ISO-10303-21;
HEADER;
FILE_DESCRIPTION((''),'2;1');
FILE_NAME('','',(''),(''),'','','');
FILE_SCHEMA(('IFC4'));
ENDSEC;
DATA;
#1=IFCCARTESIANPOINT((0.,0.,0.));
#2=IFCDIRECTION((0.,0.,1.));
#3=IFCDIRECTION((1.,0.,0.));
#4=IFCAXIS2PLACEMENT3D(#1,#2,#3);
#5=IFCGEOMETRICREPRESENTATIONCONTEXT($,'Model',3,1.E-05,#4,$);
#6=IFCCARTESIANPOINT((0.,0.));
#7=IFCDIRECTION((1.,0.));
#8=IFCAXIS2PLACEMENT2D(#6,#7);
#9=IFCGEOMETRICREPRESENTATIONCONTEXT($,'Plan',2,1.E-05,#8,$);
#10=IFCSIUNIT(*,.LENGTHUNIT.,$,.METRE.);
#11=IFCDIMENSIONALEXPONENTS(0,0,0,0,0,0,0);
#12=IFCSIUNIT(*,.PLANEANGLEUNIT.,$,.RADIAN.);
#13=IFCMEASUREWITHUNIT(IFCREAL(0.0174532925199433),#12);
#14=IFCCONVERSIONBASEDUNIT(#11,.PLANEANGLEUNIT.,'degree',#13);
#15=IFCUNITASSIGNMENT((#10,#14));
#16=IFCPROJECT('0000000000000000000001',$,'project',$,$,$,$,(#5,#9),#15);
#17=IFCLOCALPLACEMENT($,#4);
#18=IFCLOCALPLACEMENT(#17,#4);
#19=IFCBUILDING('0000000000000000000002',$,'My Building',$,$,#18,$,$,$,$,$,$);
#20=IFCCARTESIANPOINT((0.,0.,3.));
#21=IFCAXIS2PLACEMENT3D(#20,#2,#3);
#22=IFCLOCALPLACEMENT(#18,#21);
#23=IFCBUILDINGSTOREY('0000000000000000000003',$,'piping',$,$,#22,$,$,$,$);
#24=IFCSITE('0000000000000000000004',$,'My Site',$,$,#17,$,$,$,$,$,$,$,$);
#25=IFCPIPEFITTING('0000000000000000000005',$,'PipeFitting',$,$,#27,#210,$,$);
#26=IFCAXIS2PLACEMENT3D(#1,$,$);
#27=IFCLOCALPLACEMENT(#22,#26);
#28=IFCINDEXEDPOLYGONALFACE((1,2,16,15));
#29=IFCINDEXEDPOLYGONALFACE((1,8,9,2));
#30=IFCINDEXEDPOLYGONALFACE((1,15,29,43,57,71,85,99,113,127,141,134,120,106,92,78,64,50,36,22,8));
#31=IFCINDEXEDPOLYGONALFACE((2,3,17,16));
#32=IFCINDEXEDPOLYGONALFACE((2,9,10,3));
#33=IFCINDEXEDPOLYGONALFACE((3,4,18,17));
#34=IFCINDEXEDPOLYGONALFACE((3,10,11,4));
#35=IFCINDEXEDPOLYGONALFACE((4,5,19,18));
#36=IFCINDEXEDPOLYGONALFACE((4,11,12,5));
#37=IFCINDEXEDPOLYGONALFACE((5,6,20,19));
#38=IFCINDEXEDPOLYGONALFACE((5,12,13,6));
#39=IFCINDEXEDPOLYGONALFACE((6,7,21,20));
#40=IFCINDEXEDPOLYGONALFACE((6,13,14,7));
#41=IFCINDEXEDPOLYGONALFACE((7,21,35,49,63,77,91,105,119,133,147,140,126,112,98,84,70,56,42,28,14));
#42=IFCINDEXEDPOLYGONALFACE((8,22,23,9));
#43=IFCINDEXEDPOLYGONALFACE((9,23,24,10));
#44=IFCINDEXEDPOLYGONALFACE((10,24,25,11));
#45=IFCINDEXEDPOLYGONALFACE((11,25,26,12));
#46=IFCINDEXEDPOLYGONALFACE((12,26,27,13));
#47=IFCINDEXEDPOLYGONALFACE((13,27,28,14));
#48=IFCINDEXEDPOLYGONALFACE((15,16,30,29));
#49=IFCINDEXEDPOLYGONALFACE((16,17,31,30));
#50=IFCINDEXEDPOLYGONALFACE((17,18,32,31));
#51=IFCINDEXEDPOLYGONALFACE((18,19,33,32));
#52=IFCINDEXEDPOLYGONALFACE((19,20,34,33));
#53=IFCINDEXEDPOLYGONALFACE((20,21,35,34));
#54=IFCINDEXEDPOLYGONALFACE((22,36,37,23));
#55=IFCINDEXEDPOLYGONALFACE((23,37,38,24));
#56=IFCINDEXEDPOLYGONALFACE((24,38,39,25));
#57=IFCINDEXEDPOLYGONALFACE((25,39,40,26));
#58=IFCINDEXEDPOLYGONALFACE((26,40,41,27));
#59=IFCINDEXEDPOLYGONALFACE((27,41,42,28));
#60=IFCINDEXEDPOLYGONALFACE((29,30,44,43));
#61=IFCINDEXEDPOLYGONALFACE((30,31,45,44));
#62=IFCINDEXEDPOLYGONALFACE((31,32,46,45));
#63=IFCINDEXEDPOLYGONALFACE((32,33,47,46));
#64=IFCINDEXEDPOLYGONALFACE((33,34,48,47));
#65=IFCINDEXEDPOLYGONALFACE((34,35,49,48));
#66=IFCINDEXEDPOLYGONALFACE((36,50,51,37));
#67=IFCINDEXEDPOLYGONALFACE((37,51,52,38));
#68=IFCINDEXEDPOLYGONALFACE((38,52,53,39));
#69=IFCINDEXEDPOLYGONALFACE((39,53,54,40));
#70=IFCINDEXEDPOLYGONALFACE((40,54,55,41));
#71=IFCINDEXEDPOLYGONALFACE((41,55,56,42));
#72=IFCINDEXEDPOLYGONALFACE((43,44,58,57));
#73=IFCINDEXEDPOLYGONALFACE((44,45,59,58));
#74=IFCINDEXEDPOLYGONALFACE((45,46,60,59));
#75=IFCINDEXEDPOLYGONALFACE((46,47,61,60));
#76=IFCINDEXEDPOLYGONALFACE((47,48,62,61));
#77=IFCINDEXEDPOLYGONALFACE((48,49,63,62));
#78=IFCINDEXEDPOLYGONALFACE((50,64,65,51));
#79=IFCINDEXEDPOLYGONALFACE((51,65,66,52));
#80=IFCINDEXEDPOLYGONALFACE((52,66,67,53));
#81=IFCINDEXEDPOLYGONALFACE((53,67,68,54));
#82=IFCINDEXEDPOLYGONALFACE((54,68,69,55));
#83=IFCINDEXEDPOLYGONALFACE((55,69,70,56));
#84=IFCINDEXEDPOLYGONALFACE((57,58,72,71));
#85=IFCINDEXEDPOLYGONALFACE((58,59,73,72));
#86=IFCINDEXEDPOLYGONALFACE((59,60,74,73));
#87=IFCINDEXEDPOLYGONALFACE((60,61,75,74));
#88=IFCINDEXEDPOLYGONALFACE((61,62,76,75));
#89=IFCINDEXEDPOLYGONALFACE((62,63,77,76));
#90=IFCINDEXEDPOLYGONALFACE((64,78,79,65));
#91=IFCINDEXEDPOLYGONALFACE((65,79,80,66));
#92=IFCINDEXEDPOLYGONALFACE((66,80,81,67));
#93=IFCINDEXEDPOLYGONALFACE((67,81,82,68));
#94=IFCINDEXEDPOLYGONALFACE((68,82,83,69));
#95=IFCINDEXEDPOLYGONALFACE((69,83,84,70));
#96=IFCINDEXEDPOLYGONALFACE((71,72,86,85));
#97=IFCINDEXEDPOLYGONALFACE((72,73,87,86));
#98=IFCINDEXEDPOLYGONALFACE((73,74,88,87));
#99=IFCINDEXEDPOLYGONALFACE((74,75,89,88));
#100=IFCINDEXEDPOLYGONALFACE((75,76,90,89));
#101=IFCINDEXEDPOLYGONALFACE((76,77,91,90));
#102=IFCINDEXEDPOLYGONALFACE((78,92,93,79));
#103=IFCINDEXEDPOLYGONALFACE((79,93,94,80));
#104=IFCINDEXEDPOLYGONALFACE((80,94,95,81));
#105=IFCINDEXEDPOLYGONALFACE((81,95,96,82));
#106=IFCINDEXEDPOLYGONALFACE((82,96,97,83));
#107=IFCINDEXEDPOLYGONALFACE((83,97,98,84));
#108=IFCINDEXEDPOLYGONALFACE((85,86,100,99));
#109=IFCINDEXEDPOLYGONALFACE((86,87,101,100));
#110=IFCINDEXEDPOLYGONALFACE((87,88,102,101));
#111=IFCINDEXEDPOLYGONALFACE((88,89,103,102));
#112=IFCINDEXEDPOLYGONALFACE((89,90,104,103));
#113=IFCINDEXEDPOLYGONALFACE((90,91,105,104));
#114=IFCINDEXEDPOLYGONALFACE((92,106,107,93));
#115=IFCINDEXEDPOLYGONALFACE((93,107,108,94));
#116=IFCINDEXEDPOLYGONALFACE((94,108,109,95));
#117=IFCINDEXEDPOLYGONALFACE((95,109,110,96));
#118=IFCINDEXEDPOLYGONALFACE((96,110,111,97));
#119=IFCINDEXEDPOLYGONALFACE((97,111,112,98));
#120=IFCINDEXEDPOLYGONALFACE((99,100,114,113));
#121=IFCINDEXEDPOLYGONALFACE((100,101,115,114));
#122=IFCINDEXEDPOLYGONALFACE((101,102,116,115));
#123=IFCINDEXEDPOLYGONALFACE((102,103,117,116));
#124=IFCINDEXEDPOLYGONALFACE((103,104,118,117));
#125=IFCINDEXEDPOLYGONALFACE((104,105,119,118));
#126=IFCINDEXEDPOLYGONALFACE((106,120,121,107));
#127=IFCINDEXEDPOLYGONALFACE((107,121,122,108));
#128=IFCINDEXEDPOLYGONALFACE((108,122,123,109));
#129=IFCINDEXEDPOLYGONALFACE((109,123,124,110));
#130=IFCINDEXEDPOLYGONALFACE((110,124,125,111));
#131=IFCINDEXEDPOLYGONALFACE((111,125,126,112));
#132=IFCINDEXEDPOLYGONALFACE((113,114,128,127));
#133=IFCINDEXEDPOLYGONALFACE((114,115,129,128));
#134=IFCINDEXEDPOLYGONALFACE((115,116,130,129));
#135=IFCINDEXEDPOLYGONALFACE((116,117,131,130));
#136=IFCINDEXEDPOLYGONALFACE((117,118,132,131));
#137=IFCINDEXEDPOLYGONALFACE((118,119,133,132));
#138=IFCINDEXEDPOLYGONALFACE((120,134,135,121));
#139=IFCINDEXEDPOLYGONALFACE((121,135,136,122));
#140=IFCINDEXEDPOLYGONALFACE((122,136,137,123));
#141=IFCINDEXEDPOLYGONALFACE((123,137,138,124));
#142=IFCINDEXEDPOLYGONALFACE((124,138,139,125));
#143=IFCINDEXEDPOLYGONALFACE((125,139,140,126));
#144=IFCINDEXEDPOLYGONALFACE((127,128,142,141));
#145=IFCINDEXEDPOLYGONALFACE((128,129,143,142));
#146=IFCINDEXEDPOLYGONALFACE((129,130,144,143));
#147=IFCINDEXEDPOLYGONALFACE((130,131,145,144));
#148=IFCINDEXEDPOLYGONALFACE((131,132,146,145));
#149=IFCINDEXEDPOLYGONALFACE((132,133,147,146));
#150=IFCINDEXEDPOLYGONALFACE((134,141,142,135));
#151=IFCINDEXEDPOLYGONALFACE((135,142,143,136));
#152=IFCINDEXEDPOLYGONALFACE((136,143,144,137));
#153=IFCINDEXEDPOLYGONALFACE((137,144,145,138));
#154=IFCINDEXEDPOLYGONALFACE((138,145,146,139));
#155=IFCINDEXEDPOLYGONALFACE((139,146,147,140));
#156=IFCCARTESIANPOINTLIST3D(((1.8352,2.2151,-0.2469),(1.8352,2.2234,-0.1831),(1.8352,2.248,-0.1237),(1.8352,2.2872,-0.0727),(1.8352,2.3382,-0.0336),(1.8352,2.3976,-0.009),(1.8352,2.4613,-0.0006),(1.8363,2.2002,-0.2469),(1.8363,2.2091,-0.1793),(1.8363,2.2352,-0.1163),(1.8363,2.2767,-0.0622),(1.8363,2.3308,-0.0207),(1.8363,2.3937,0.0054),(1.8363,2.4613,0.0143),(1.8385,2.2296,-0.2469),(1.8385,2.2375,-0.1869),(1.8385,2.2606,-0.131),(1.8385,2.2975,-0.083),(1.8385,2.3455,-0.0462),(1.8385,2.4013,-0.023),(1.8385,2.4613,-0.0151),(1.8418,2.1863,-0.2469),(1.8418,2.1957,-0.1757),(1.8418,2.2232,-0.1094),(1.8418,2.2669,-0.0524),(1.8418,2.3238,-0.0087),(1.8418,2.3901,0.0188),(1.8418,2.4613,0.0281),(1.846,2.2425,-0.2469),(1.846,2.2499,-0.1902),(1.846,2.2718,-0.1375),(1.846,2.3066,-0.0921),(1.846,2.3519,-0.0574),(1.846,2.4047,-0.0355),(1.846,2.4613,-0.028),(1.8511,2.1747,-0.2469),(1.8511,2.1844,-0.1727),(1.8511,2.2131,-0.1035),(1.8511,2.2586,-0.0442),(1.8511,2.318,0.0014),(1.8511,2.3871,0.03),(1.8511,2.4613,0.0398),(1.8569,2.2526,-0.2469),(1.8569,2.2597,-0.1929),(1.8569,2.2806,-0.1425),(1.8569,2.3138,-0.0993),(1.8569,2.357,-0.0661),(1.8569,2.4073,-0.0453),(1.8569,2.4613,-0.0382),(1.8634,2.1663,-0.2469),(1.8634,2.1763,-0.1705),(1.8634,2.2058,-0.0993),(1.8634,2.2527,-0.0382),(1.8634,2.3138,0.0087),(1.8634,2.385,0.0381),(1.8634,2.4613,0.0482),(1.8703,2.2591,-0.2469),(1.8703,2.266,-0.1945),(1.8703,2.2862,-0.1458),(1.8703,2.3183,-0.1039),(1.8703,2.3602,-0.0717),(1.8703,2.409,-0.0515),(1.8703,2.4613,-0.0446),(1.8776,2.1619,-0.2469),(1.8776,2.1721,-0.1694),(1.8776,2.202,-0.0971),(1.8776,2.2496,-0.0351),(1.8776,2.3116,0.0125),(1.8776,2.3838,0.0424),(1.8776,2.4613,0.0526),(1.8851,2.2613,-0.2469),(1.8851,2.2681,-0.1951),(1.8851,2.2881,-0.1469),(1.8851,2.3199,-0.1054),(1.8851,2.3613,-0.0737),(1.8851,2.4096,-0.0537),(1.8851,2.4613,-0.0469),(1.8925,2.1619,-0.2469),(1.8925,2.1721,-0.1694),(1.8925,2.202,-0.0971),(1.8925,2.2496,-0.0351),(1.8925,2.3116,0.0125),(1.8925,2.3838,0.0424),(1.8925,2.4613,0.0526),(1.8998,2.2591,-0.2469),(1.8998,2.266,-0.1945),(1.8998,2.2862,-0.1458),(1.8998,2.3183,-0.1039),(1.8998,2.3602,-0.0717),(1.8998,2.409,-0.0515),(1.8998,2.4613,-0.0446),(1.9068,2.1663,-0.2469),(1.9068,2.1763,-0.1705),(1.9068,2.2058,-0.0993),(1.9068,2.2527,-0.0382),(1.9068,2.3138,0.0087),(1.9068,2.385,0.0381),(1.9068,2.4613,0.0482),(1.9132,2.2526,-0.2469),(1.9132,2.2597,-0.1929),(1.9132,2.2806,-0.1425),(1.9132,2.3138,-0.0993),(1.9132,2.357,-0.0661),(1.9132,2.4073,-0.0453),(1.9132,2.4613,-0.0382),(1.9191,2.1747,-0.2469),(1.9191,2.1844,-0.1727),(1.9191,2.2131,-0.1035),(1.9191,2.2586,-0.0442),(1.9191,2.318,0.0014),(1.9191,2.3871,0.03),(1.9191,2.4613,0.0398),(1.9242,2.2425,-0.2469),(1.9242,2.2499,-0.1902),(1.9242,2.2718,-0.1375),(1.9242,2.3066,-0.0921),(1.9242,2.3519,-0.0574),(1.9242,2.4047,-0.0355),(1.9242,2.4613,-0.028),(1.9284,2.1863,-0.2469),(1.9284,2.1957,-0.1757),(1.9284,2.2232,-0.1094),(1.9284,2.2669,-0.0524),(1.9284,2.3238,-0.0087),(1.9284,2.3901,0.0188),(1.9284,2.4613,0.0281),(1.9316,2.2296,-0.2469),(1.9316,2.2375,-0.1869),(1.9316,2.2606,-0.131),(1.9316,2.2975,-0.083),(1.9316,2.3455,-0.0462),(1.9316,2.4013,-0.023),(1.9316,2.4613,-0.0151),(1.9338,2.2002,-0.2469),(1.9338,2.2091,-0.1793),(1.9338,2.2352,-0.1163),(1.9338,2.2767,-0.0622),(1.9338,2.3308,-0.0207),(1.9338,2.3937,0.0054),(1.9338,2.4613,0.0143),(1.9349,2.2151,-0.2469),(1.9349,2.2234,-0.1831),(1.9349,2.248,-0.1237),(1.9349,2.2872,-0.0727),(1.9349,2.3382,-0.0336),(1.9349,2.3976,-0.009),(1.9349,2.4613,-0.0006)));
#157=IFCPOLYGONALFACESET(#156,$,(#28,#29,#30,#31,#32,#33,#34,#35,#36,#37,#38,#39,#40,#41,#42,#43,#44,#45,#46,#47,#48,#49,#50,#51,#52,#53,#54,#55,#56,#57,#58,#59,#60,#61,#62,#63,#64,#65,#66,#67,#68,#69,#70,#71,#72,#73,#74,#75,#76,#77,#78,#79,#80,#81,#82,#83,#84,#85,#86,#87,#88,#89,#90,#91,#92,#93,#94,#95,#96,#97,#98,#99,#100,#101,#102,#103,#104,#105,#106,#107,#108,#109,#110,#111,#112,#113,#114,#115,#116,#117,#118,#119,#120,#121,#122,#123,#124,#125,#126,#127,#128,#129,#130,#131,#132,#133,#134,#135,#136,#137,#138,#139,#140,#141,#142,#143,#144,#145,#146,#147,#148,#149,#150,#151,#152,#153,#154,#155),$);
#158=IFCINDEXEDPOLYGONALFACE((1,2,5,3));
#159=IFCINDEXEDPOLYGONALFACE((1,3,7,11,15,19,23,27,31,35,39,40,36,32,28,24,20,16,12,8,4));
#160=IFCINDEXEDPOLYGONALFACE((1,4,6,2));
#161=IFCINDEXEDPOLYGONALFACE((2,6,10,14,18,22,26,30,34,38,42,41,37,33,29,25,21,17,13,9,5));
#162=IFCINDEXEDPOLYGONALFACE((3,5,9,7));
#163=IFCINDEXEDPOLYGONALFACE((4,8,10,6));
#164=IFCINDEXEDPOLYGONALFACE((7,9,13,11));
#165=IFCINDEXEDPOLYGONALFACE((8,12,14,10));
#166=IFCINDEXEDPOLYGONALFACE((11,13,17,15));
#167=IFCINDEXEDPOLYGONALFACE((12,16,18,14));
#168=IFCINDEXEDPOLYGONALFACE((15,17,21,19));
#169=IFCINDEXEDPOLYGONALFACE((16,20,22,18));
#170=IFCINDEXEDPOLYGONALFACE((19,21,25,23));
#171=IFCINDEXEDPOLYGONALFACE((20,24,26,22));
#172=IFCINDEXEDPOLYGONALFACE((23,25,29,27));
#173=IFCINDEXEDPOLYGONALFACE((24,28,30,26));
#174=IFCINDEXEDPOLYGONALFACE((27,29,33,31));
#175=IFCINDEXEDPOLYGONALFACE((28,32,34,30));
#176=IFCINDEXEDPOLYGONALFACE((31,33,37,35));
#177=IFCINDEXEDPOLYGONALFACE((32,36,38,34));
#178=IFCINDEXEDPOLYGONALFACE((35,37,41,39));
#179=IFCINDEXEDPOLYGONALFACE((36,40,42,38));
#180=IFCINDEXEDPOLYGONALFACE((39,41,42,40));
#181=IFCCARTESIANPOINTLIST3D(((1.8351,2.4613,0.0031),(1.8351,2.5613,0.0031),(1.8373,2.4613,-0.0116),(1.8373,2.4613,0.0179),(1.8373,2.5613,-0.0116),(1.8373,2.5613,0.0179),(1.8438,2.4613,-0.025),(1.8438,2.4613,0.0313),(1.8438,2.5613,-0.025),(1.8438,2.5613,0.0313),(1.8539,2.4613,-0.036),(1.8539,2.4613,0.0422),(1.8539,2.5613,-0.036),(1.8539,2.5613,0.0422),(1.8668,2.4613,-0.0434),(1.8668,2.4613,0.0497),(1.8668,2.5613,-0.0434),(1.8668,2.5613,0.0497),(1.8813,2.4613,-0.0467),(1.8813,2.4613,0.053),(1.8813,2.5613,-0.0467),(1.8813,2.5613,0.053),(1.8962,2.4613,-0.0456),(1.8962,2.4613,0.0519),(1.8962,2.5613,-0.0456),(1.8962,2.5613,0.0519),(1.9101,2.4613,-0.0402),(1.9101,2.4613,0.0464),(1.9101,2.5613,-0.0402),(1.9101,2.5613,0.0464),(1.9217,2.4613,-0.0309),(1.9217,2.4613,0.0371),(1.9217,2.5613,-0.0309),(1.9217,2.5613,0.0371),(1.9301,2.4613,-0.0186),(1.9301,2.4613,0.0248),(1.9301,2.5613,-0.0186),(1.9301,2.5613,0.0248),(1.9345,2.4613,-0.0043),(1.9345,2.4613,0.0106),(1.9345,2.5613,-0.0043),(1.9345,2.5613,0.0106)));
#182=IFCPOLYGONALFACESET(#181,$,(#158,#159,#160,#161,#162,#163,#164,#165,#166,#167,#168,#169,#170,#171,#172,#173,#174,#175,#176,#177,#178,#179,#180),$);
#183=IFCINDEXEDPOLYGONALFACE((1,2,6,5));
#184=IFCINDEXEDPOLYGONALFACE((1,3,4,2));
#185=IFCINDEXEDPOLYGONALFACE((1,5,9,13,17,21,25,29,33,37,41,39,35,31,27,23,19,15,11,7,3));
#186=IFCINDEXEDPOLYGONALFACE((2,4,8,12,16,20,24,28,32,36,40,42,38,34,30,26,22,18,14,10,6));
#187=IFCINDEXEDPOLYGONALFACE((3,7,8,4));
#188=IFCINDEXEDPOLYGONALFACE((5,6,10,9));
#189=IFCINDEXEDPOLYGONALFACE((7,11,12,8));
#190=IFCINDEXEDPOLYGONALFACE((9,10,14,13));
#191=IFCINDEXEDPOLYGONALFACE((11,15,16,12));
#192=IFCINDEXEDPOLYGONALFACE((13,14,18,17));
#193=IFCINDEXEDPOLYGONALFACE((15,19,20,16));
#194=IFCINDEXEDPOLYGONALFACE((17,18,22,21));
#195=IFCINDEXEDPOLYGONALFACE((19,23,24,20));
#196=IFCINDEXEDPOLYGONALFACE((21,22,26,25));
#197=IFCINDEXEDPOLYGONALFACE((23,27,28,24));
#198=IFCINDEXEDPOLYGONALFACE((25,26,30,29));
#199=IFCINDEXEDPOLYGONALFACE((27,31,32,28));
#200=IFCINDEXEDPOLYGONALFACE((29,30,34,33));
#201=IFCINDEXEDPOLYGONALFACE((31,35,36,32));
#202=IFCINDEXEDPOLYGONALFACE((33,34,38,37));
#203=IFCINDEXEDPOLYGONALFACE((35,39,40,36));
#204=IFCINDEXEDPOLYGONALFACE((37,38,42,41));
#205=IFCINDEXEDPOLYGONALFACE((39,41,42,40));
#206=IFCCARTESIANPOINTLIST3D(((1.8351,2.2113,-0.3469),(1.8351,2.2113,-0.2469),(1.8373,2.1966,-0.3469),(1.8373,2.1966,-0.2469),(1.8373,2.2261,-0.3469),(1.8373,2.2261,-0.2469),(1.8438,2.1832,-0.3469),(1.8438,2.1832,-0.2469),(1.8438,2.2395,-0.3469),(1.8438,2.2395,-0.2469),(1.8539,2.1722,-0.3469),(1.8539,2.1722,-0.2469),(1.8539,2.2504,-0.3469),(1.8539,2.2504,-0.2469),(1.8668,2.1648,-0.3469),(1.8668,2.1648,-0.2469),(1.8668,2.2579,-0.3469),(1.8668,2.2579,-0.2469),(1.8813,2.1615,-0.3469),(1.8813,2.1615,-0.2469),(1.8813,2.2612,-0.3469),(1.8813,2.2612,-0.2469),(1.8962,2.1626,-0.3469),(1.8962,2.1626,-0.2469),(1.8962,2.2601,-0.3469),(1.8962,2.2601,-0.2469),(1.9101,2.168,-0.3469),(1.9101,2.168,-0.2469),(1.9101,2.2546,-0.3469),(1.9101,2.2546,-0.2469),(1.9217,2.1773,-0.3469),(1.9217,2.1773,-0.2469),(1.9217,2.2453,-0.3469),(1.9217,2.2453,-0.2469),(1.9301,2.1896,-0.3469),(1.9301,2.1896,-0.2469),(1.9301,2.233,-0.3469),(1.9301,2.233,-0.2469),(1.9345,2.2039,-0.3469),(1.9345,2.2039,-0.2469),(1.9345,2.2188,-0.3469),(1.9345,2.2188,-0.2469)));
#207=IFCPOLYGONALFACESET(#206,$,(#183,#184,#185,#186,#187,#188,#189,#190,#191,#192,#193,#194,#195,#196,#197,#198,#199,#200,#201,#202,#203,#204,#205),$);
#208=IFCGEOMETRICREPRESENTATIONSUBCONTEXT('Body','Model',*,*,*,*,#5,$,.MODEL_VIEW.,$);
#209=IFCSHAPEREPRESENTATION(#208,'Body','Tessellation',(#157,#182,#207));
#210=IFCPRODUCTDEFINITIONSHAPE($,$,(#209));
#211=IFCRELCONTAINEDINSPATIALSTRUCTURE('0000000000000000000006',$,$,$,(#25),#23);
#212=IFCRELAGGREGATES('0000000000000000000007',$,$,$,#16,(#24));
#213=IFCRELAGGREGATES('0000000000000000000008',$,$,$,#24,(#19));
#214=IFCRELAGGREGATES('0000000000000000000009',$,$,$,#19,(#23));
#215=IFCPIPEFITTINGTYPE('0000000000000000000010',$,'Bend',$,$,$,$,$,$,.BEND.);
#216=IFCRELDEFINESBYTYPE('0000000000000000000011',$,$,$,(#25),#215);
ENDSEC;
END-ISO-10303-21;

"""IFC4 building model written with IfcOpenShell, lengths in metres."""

from ifc_helpers import new_model, entity, si_unit, converted_unit, frame, origin_with_axes, origin_2d_with_axis, place, context, subcontext, project, spatial, circle, extrude, source, transform, mapped, type_object, type_shapes, element, save


model = new_model("IFC4")

# Units and contexts
model_context = context("Model", 3, precision=1e-05, world=origin_with_axes())
plan_context = context("Plan", 2, precision=1e-05, world=origin_2d_with_axis())
body_context = subcontext(model_context, "Body", "Model", "MODEL_VIEW")
ifc_project = project(units=[si_unit("LENGTHUNIT", "METRE"), converted_unit("PLANEANGLEUNIT", "degree", entity("IfcReal", 0.0174532925199433), si_unit("PLANEANGLEUNIT", "RADIAN"), dimensions=[0, 0, 0, 0, 0, 0, 0])], contexts=[model_context, plan_context])

# Site, building, storey
site_placement = place(None, origin_with_axes())
site = spatial("IfcSite", under=ifc_project, at=site_placement, Name="My Site")
building_placement = place(site_placement, origin_with_axes())
building = spatial("IfcBuilding", under=site, at=building_placement, Name="My Building")
storey_placement = place(building_placement, frame((0.0, 0.0, 3.0), z_axis=(0.0, 0.0, 1.0), x_axis=(1.0, 0.0, 0.0)))
storey = spatial("IfcBuildingStorey", under=building, at=storey_placement, Name="piping")

# Pipe fitting
pipe_fitting_type = type_object("IfcPipeFittingType", Name="Bend", PredefinedType="BEND")
shared_shape = source(origin_with_axes(), body_context, "Body", "SolidModel", [
    entity("IfcSweptDiskSolid", entity("IfcIndexedPolyCurve", entity("IfcCartesianPointList3D", [[0.0, 0.0, -0.1], [0.0, -0.0732, -0.2768], [0.0, -0.25, -0.35]]), [entity("IfcArcIndex", [1, 2, 3])]), 0.05),
    extrude(circle(Radius=0.05), origin_with_axes(), (0.0, 0.0, -1.0), 0.1),
    extrude(circle(Radius=0.05), frame((0.0, -0.25, -0.35), z_axis=(0.0, -1.0, 0.0), x_axis=(1.0, 0.0, 0.0)), (0.0, 0.0, 1.0), 0.1),
])
type_shapes(pipe_fitting_type, [shared_shape])
for number, where, z_axis, x_axis, name in (
    (1, (1.8851, 2.5613, 0.0031), (0.0, 1.0, 0.0), (-1.0, 0.0, 0.0), "PipeFitting"),
):
    element("IfcPipeFitting", number, at=place(storey_placement, frame(where, z_axis=z_axis, x_axis=x_axis)), inside=storey, type_object=pipe_fitting_type, Name=name, context=body_context, shape_type="MappedRepresentation", body=[
        mapped(shared_shape, transform((0.0, 0.0, 0.0), x_axis=(1.0, 0.0, 0.0), y_axis=(0.0, 1.0, 0.0), z_axis=(0.0, 0.0, 1.0), scale=1.0)),
    ])

save(model, "model.ifc")
